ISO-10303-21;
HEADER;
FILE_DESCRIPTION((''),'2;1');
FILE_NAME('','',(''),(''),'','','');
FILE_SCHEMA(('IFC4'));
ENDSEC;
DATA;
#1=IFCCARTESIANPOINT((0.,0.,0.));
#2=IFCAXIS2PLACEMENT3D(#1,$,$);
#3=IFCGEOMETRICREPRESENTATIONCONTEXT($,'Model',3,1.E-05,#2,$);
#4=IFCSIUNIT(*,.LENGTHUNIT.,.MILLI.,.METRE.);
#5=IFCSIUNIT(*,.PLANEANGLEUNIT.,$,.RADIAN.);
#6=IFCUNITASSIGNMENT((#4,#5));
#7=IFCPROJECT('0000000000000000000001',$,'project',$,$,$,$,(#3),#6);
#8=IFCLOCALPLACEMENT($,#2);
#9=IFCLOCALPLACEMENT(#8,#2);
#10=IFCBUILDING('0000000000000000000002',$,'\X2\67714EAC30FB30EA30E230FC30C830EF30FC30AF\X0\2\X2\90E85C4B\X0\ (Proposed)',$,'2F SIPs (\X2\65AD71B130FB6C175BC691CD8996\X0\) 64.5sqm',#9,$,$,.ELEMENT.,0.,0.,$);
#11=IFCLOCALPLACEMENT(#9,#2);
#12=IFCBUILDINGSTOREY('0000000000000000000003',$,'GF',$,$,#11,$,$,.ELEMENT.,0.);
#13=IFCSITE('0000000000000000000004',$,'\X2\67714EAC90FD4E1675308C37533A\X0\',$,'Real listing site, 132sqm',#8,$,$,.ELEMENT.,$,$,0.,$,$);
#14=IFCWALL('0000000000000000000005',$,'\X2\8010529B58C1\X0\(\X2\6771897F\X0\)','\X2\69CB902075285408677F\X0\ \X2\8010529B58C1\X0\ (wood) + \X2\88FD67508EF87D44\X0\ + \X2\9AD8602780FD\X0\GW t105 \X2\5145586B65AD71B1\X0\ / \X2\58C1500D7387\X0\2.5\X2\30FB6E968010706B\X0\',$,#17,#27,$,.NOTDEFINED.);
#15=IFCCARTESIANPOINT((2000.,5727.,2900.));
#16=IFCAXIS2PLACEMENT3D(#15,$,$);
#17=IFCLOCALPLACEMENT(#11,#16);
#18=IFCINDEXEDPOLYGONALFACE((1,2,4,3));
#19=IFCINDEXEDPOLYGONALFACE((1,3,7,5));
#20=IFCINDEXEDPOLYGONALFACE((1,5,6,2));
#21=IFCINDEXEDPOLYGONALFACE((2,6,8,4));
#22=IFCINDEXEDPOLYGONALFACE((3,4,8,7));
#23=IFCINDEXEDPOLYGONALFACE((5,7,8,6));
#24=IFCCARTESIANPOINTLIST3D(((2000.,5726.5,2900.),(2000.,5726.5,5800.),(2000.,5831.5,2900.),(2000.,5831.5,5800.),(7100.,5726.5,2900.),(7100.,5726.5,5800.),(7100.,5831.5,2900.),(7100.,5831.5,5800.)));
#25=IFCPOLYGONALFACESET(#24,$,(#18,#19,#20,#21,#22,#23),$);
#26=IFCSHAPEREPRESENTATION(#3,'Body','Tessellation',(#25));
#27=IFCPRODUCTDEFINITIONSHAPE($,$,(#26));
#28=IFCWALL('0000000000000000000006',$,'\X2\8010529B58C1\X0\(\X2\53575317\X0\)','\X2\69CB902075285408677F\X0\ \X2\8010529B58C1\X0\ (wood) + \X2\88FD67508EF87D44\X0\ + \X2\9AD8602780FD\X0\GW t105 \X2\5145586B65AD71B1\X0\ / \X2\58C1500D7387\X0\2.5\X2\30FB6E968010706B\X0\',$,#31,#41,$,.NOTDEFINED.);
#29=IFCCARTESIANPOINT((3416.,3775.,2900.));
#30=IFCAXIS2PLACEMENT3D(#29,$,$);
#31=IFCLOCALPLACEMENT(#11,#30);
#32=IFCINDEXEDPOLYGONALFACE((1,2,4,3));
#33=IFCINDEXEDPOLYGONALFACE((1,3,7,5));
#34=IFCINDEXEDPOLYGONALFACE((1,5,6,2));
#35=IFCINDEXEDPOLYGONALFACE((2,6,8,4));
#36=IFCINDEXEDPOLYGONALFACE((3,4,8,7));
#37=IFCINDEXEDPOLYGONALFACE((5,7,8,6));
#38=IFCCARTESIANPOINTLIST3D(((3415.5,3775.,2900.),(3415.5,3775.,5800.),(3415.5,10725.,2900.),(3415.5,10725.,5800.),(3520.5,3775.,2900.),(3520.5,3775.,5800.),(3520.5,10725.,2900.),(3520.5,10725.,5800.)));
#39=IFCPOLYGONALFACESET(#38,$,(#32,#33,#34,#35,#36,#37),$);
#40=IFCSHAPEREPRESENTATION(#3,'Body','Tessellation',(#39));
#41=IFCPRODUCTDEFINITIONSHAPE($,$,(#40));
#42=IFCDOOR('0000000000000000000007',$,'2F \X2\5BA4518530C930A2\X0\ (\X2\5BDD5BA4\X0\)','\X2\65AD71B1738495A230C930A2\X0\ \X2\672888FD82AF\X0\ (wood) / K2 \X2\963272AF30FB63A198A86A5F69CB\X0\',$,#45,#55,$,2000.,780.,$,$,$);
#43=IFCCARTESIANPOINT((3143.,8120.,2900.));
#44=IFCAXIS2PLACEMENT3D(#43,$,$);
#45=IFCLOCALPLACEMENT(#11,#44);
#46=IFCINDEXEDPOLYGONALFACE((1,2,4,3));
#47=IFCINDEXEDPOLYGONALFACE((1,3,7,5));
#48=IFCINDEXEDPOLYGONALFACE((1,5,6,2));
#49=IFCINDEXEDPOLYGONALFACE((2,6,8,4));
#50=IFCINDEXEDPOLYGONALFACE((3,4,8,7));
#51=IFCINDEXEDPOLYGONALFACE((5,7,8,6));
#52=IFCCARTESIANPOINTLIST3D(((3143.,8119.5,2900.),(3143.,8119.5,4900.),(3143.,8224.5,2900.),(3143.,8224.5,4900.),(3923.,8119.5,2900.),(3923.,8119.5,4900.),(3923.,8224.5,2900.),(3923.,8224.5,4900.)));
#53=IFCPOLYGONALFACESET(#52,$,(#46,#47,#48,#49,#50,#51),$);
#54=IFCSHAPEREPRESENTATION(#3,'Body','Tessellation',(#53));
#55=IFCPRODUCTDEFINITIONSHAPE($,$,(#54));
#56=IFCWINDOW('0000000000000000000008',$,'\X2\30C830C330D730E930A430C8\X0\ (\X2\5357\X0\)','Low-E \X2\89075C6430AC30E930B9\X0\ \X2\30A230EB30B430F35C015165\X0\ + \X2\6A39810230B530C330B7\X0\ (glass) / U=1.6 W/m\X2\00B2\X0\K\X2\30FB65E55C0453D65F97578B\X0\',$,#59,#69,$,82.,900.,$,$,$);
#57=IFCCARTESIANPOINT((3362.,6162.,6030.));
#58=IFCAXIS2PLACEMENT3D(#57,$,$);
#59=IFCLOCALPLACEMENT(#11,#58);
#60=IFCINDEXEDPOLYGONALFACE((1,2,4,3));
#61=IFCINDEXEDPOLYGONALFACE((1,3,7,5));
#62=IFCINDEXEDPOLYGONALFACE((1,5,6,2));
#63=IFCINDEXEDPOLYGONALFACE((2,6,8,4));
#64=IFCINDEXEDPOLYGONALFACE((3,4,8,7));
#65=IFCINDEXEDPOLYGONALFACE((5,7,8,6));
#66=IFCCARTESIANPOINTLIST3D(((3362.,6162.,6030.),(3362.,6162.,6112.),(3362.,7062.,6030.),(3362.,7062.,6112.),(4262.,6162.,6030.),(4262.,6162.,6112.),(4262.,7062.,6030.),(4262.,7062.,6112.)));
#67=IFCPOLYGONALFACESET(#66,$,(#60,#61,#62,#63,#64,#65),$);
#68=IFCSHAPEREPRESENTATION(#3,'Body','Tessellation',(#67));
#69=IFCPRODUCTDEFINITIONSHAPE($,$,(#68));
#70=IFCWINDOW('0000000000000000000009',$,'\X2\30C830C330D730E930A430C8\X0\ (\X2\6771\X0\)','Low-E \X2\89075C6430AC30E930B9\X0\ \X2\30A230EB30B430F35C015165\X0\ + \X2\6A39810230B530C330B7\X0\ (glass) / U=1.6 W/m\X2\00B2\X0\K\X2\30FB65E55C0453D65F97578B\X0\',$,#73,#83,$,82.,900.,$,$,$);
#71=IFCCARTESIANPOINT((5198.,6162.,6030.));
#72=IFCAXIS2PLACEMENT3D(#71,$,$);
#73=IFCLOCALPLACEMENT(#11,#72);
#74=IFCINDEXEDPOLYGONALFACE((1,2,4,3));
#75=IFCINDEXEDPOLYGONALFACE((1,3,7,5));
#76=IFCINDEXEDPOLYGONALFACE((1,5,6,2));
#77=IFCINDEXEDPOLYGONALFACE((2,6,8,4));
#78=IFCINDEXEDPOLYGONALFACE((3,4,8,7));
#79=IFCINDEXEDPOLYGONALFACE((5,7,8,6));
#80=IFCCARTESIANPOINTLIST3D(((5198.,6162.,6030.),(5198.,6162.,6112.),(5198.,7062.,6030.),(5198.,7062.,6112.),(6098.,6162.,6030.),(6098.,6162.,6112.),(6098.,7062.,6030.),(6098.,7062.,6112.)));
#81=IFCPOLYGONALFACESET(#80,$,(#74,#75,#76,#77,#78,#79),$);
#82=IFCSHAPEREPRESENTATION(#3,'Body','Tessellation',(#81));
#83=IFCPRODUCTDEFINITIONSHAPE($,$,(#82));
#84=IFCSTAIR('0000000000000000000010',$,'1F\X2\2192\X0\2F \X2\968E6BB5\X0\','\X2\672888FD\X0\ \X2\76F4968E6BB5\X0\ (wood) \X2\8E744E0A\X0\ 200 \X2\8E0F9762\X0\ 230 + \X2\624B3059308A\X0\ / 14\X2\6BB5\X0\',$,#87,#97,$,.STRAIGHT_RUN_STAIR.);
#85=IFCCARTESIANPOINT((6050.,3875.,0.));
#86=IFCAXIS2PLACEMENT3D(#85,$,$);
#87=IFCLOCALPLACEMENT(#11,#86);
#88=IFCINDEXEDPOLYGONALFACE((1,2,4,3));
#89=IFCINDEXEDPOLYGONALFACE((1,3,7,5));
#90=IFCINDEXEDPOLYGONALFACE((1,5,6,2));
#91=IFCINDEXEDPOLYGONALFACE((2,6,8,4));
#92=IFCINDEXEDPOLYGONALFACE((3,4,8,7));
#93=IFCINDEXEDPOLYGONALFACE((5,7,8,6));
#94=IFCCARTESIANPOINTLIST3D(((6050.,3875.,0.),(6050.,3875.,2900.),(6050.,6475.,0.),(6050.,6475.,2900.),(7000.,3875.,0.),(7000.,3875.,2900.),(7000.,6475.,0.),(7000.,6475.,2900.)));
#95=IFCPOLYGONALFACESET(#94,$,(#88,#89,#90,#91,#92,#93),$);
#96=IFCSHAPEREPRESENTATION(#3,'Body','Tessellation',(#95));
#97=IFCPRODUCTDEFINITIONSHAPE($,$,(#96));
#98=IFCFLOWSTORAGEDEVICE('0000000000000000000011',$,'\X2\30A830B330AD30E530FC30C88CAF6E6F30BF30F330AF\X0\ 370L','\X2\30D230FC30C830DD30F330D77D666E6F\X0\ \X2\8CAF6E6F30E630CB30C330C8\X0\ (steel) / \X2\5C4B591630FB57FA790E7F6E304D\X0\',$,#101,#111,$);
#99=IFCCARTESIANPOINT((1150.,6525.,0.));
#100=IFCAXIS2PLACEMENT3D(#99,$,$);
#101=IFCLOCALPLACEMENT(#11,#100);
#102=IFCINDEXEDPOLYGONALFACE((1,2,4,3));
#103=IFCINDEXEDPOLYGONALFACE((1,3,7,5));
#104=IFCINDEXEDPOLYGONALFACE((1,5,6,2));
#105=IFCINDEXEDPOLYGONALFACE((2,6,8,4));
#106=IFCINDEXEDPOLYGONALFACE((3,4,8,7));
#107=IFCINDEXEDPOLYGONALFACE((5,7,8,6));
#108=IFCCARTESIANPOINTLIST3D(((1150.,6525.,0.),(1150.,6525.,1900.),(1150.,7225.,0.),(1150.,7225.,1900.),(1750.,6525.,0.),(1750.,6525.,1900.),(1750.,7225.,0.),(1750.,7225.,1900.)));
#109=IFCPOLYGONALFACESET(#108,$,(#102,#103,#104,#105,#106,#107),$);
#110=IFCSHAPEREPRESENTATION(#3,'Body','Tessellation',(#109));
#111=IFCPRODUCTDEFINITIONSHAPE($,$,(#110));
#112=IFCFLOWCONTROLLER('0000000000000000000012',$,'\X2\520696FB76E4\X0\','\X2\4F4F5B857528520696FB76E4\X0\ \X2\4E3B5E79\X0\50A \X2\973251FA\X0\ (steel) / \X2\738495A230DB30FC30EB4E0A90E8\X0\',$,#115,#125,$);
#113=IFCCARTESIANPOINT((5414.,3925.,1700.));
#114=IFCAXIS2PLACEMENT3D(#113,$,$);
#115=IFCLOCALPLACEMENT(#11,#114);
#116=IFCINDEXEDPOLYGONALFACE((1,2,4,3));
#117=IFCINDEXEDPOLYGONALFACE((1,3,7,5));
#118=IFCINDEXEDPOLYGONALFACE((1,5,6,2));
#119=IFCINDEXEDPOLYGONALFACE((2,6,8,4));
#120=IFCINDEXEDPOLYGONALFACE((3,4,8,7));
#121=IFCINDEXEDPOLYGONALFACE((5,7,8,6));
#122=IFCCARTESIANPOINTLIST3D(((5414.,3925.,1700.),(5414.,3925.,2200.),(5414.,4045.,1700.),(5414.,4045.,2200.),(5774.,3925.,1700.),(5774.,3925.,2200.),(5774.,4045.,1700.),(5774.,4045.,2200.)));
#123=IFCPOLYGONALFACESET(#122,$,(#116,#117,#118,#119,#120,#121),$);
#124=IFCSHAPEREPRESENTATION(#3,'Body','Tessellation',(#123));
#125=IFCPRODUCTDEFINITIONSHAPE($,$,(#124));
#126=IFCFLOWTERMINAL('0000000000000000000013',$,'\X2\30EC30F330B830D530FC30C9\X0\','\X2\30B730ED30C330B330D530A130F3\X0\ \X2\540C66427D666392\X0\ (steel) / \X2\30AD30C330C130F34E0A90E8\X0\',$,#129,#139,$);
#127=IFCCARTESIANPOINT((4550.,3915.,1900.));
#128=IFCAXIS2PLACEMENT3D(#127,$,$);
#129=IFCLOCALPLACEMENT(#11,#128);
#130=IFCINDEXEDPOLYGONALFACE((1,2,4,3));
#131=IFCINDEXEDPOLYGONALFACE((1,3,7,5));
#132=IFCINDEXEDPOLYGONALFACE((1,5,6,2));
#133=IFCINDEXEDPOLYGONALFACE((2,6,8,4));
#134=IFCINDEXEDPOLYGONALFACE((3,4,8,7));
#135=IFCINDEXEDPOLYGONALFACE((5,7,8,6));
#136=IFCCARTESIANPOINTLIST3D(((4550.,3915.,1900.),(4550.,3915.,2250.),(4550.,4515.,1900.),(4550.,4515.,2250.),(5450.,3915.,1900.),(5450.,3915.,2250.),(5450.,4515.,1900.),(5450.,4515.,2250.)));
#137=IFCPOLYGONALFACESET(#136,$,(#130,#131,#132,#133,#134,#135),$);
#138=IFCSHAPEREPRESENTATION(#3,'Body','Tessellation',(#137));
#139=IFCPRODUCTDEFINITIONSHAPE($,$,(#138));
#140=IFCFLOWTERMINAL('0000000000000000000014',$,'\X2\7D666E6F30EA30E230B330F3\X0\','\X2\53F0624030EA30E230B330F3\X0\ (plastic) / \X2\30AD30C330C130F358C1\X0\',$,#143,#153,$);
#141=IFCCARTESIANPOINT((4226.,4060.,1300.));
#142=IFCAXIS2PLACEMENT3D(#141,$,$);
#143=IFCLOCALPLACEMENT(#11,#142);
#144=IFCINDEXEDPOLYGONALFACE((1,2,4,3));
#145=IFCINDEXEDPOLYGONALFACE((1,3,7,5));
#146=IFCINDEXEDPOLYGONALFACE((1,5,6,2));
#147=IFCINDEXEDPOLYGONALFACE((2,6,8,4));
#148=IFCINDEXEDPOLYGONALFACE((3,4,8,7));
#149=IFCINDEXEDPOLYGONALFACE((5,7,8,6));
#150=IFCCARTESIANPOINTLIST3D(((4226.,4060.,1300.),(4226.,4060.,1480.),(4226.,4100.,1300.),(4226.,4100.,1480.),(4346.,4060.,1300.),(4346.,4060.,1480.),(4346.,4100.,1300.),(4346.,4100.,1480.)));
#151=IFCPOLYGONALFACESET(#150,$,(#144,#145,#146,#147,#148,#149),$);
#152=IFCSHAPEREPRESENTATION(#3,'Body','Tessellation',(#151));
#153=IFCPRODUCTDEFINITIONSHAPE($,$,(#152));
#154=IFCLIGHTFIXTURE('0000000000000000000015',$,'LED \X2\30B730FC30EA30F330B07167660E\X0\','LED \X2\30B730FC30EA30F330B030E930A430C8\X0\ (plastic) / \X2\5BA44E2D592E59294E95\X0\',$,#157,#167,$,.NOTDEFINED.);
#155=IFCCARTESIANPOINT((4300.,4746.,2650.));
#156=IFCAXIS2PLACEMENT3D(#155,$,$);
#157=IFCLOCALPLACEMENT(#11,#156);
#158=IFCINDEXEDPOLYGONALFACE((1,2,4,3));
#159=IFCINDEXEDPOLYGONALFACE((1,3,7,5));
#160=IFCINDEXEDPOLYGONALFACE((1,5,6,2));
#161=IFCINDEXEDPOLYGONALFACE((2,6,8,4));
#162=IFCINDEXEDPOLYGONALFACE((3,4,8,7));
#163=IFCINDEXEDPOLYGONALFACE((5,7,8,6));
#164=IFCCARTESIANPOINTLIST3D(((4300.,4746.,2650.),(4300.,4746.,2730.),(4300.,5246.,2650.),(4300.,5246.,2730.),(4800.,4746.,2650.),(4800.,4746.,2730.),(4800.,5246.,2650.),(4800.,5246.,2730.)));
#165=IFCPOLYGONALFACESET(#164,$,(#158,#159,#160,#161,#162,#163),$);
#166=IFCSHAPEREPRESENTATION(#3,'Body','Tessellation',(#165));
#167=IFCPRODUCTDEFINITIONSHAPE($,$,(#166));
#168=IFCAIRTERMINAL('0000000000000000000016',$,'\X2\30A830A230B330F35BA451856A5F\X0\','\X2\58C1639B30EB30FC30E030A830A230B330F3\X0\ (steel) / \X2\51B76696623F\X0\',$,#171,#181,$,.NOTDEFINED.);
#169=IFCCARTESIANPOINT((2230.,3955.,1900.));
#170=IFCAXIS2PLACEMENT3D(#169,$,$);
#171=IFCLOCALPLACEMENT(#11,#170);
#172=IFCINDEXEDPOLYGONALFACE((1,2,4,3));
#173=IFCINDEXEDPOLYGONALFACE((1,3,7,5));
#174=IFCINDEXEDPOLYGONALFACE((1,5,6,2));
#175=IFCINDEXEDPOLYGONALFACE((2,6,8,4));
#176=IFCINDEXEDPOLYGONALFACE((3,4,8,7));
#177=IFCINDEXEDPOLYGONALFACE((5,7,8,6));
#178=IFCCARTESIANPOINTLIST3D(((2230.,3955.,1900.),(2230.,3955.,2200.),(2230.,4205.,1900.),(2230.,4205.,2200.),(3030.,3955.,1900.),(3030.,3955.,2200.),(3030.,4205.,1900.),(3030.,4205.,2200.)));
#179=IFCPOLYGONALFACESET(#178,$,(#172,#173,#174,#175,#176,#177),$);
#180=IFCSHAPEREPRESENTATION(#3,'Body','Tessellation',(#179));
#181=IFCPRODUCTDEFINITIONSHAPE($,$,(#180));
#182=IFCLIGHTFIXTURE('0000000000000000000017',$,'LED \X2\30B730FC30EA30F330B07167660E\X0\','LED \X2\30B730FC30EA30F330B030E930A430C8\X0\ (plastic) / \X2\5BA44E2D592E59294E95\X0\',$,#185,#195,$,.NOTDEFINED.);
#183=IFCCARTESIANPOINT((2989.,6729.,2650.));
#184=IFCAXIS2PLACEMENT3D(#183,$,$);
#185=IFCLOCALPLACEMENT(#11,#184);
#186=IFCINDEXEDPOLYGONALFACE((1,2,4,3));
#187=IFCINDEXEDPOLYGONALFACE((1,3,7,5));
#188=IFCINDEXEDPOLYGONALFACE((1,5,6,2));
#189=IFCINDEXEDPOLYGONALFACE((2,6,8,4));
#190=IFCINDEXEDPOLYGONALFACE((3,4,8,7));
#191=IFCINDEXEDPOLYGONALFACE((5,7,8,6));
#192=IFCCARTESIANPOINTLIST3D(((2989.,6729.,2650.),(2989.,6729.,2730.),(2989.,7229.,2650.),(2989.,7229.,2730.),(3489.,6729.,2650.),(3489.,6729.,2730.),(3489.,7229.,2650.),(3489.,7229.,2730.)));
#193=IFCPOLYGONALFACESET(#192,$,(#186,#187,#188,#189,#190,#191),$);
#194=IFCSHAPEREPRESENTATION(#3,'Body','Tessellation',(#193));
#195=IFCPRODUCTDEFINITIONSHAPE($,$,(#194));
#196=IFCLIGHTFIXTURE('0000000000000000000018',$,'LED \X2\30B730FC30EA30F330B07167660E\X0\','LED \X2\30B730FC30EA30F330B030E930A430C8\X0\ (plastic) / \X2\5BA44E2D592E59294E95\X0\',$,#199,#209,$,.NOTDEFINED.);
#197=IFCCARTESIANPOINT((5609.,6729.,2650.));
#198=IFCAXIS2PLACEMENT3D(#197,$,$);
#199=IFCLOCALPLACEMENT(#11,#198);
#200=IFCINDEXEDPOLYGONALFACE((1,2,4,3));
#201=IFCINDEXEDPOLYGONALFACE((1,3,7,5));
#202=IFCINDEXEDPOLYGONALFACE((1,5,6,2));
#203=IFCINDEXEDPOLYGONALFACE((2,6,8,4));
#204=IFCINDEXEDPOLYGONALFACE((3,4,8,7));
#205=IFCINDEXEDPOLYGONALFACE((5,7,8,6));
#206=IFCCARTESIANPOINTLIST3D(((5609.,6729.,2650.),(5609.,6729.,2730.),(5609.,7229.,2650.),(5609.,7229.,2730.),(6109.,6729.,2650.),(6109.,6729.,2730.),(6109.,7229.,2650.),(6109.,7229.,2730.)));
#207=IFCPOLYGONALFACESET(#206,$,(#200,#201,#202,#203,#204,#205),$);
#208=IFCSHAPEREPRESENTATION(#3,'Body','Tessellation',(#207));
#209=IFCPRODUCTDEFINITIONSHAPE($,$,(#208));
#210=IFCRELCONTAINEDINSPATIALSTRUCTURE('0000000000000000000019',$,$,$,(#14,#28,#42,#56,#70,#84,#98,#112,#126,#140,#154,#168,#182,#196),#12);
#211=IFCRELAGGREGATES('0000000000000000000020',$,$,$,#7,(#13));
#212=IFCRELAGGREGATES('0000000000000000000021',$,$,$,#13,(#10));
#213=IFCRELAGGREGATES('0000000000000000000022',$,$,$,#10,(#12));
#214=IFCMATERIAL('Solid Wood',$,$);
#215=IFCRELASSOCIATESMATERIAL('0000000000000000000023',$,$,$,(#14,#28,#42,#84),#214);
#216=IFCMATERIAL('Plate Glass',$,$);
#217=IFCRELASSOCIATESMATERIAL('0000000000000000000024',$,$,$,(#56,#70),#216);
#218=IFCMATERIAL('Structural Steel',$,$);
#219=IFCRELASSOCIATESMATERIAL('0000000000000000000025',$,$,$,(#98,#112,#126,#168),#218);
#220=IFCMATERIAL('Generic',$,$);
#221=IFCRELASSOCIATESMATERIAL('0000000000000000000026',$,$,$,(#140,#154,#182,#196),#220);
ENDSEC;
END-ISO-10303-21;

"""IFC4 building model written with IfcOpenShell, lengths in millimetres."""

from ifc_helpers import new_model, si_unit, frame, frame_2d, origin, place, context, project, spatial, rectangle, extrude, material, element, fill, save


model = new_model("IFC4")

# Units and contexts
model_context = context("Model", 3, precision=1e-05, world=origin())
ifc_project = project(units=[si_unit("LENGTHUNIT", "METRE", prefix="MILLI"), si_unit("PLANEANGLEUNIT", "RADIAN")], contexts=[model_context])

# Site, building, storey
site_placement = place(None, origin())
site = spatial("IfcSite", under=ifc_project, at=site_placement, Name="東京都世田谷区", ObjectType="Real listing site, 132sqm", CompositionType="ELEMENT", RefElevation=0.0)
building_placement = place(site_placement, origin())
building = spatial("IfcBuilding", under=site, at=building_placement, Name="東京・リモートワーク2部屋 (Proposed)", ObjectType="2F SIPs (断熱・気密重視) 64.5sqm", CompositionType="ELEMENT", ElevationOfRefHeight=0.0, ElevationOfTerrain=0.0)
storey_placement = place(building_placement, origin())
storey = spatial("IfcBuildingStorey", under=building, at=storey_placement, Name="GF", CompositionType="ELEMENT", Elevation=0.0)

# Shared definitions
ifc_material_1 = material(Name="Solid Wood")

# Wall
wall_1_placement = place(storey_placement, frame((2000.0, 5727.0, 2900.0)))
element("IfcWall", 1, at=wall_1_placement, inside=storey, material=ifc_material_1, Name="耐力壁(東西)", Description="構造用合板 耐力壁 (wood) + 製材軸組 + 高性能GW t105 充填断熱 / 壁倍率2.5・準耐火", PredefinedType="NOTDEFINED", context=model_context, shape_type="SweptSolid", body=[
    extrude(rectangle(XDim=5100.0, YDim=105.0, at=frame_2d((2550.0, 52.0))), frame((2000.0, 5727.0, 2900.0)), (0.0, 0.0, 1.0), 2900.0),
])

# Wall, opening, door
wall_2_placement = place(storey_placement, frame((3416.0, 3775.0, 2900.0)))
wall_2 = element("IfcWall", 2, at=wall_2_placement, inside=storey, material=ifc_material_1, Name="耐力壁(南北)", Description="構造用合板 耐力壁 (wood) + 製材軸組 + 高性能GW t105 充填断熱 / 壁倍率2.5・準耐火", PredefinedType="NOTDEFINED", context=model_context, shape_type="SweptSolid", body=[
    extrude(rectangle(XDim=105.0, YDim=6950.0, at=frame_2d((52.0, 3475.0))), frame((3416.0, 3775.0, 2900.0)), (0.0, 0.0, 1.0), 2900.0),
])
opening_placement = place(storey_placement, frame((3143.0, 8120.0, 2900.0)))
opening = element("IfcOpeningElement", 3, at=opening_placement, cuts=wall_2, PredefinedType="NOTDEFINED", context=model_context, shape_type="SweptSolid", body=[
    extrude(rectangle(XDim=780.0, YDim=105.0, at=frame_2d((390.0, 52.0))), frame((3143.0, 8120.0, 2900.0)), (0.0, 0.0, 1.0), 2000.0),
])
door_placement = place(storey_placement, frame((3143.0, 8120.0, 2900.0)))
door = element("IfcDoor", 4, at=door_placement, inside=storey, material=ifc_material_1, Name="2F 室内ドア (寝室)", Description="断熱玄関ドア 木製芯 (wood) / K2 防犯・採風機構", OverallHeight=2000.0, OverallWidth=780.0, context=model_context, shape_type="SweptSolid", body=[
    extrude(rectangle(XDim=780.0, YDim=105.0, at=frame_2d((390.0, 52.0))), frame((3143.0, 8120.0, 2900.0)), (0.0, 0.0, 1.0), 2000.0),
])
fill(opening, door)

# Windows
ifc_material_2 = material(Name="Plate Glass")
window_1_placement = place(storey_placement, frame((3362.0, 6162.0, 6030.0)))
element("IfcWindow", 5, at=window_1_placement, inside=storey, material=ifc_material_2, Name="トップライト (南)", Description="Low-E 複層ガラス アルゴン封入 + 樹脂サッシ (glass) / U=1.6 W/m²K・日射取得型", OverallHeight=82.0, OverallWidth=900.0, context=model_context, shape_type="SweptSolid", body=[
    extrude(rectangle(XDim=900.0, YDim=900.0, at=frame_2d((450.0, 450.0))), frame((3362.0, 6162.0, 6030.0)), (0.0, 0.0, 1.0), 82.0),
])
window_2_placement = place(storey_placement, frame((5198.0, 6162.0, 6030.0)))
element("IfcWindow", 6, at=window_2_placement, inside=storey, material=ifc_material_2, Name="トップライト (東)", Description="Low-E 複層ガラス アルゴン封入 + 樹脂サッシ (glass) / U=1.6 W/m²K・日射取得型", OverallHeight=82.0, OverallWidth=900.0, context=model_context, shape_type="SweptSolid", body=[
    extrude(rectangle(XDim=900.0, YDim=900.0, at=frame_2d((450.0, 450.0))), frame((5198.0, 6162.0, 6030.0)), (0.0, 0.0, 1.0), 82.0),
])

# Stair
stair_placement = place(storey_placement, frame((6050.0, 3875.0, 0.0)))
element("IfcStair", 7, at=stair_placement, inside=storey, material=ifc_material_1, Name="1F→2F 階段", Description="木製 直階段 (wood) 蹴上 200 踏面 230 + 手すり / 14段", PredefinedType="STRAIGHT_RUN_STAIR", context=model_context, shape_type="SweptSolid", body=[
    extrude(rectangle(XDim=950.0, YDim=2600.0, at=frame_2d((475.0, 1300.0))), frame((6050.0, 3875.0, 0.0)), (0.0, 0.0, 1.0), 2900.0),
])

# Flow storage device
ifc_material_3 = material(Name="Structural Steel")
flow_storage_device_placement = place(storey_placement, frame((1150.0, 6525.0, 0.0)))
element("IfcFlowStorageDevice", 8, at=flow_storage_device_placement, inside=storey, material=ifc_material_3, Name="エコキュート貯湯タンク 370L", Description="ヒートポンプ給湯 貯湯ユニット (steel) / 屋外・基礎置き", context=model_context, shape_type="SweptSolid", body=[
    extrude(rectangle(XDim=600.0, YDim=700.0, at=frame_2d((300.0, 350.0))), frame((1150.0, 6525.0, 0.0)), (0.0, 0.0, 1.0), 1900.0),
])

# Flow controller
flow_controller_placement = place(storey_placement, frame((5414.0, 3925.0, 1700.0)))
element("IfcFlowController", 9, at=flow_controller_placement, inside=storey, material=ifc_material_3, Name="分電盤", Description="住宅用分電盤 主幹50A 露出 (steel) / 玄関ホール上部", context=model_context, shape_type="SweptSolid", body=[
    extrude(rectangle(XDim=360.0, YDim=120.0, at=frame_2d((180.0, 60.0))), frame((5414.0, 3925.0, 1700.0)), (0.0, 0.0, 1.0), 500.0),
])

# Flow terminals
flow_terminal_1_placement = place(storey_placement, frame((4550.0, 3915.0, 1900.0)))
element("IfcFlowTerminal", 10, at=flow_terminal_1_placement, inside=storey, material=ifc_material_3, Name="レンジフード", Description="シロッコファン 同時給排 (steel) / キッチン上部", context=model_context, shape_type="SweptSolid", body=[
    extrude(rectangle(XDim=900.0, YDim=600.0, at=frame_2d((450.0, 300.0))), frame((4550.0, 3915.0, 1900.0)), (0.0, 0.0, 1.0), 350.0),
])
ifc_material_4 = material(Name="Generic")
flow_terminal_2_placement = place(storey_placement, frame((4226.0, 4060.0, 1300.0)))
element("IfcFlowTerminal", 11, at=flow_terminal_2_placement, inside=storey, material=ifc_material_4, Name="給湯リモコン", Description="台所リモコン (plastic) / キッチン壁", context=model_context, shape_type="SweptSolid", body=[
    extrude(rectangle(XDim=120.0, YDim=40.0, at=frame_2d((60.0, 20.0))), frame((4226.0, 4060.0, 1300.0)), (0.0, 0.0, 1.0), 180.0),
])

# Light fixture
light_fixture_1_placement = place(storey_placement, frame((4300.0, 4746.0, 2650.0)))
element("IfcLightFixture", 12, at=light_fixture_1_placement, inside=storey, material=ifc_material_4, Name="LED シーリング照明", Description="LED シーリングライト (plastic) / 室中央天井", PredefinedType="NOTDEFINED", context=model_context, shape_type="SweptSolid", body=[
    extrude(rectangle(XDim=500.0, YDim=500.0, at=frame_2d((250.0, 250.0))), frame((4300.0, 4746.0, 2650.0)), (0.0, 0.0, 1.0), 80.0),
])

# Air terminal
air_terminal_1_placement = place(storey_placement, frame((2230.0, 3955.0, 1900.0)))
element("IfcAirTerminal", 13, at=air_terminal_1_placement, inside=storey, material=ifc_material_3, Name="エアコン室内機", Description="壁掛ルームエアコン (steel) / 冷暖房", PredefinedType="NOTDEFINED", context=model_context, shape_type="SweptSolid", body=[
    extrude(rectangle(XDim=800.0, YDim=250.0, at=frame_2d((400.0, 125.0))), frame((2230.0, 3955.0, 1900.0)), (0.0, 0.0, 1.0), 300.0),
])

# Light fixtures
light_fixture_2_placement = place(storey_placement, frame((2989.0, 6729.0, 2650.0)))
element("IfcLightFixture", 14, at=light_fixture_2_placement, inside=storey, material=ifc_material_4, Name="LED シーリング照明", Description="LED シーリングライト (plastic) / 室中央天井", PredefinedType="NOTDEFINED", context=model_context, shape_type="SweptSolid", body=[
    extrude(rectangle(XDim=500.0, YDim=500.0, at=frame_2d((250.0, 250.0))), frame((2989.0, 6729.0, 2650.0)), (0.0, 0.0, 1.0), 80.0),
])
light_fixture_3_placement = place(storey_placement, frame((5609.0, 6729.0, 2650.0)))
element("IfcLightFixture", 15, at=light_fixture_3_placement, inside=storey, material=ifc_material_4, Name="LED シーリング照明", Description="LED シーリングライト (plastic) / 室中央天井", PredefinedType="NOTDEFINED", context=model_context, shape_type="SweptSolid", body=[
    extrude(rectangle(XDim=500.0, YDim=500.0, at=frame_2d((250.0, 250.0))), frame((5609.0, 6729.0, 2650.0)), (0.0, 0.0, 1.0), 80.0),
])

save(model, "model.ifc")
